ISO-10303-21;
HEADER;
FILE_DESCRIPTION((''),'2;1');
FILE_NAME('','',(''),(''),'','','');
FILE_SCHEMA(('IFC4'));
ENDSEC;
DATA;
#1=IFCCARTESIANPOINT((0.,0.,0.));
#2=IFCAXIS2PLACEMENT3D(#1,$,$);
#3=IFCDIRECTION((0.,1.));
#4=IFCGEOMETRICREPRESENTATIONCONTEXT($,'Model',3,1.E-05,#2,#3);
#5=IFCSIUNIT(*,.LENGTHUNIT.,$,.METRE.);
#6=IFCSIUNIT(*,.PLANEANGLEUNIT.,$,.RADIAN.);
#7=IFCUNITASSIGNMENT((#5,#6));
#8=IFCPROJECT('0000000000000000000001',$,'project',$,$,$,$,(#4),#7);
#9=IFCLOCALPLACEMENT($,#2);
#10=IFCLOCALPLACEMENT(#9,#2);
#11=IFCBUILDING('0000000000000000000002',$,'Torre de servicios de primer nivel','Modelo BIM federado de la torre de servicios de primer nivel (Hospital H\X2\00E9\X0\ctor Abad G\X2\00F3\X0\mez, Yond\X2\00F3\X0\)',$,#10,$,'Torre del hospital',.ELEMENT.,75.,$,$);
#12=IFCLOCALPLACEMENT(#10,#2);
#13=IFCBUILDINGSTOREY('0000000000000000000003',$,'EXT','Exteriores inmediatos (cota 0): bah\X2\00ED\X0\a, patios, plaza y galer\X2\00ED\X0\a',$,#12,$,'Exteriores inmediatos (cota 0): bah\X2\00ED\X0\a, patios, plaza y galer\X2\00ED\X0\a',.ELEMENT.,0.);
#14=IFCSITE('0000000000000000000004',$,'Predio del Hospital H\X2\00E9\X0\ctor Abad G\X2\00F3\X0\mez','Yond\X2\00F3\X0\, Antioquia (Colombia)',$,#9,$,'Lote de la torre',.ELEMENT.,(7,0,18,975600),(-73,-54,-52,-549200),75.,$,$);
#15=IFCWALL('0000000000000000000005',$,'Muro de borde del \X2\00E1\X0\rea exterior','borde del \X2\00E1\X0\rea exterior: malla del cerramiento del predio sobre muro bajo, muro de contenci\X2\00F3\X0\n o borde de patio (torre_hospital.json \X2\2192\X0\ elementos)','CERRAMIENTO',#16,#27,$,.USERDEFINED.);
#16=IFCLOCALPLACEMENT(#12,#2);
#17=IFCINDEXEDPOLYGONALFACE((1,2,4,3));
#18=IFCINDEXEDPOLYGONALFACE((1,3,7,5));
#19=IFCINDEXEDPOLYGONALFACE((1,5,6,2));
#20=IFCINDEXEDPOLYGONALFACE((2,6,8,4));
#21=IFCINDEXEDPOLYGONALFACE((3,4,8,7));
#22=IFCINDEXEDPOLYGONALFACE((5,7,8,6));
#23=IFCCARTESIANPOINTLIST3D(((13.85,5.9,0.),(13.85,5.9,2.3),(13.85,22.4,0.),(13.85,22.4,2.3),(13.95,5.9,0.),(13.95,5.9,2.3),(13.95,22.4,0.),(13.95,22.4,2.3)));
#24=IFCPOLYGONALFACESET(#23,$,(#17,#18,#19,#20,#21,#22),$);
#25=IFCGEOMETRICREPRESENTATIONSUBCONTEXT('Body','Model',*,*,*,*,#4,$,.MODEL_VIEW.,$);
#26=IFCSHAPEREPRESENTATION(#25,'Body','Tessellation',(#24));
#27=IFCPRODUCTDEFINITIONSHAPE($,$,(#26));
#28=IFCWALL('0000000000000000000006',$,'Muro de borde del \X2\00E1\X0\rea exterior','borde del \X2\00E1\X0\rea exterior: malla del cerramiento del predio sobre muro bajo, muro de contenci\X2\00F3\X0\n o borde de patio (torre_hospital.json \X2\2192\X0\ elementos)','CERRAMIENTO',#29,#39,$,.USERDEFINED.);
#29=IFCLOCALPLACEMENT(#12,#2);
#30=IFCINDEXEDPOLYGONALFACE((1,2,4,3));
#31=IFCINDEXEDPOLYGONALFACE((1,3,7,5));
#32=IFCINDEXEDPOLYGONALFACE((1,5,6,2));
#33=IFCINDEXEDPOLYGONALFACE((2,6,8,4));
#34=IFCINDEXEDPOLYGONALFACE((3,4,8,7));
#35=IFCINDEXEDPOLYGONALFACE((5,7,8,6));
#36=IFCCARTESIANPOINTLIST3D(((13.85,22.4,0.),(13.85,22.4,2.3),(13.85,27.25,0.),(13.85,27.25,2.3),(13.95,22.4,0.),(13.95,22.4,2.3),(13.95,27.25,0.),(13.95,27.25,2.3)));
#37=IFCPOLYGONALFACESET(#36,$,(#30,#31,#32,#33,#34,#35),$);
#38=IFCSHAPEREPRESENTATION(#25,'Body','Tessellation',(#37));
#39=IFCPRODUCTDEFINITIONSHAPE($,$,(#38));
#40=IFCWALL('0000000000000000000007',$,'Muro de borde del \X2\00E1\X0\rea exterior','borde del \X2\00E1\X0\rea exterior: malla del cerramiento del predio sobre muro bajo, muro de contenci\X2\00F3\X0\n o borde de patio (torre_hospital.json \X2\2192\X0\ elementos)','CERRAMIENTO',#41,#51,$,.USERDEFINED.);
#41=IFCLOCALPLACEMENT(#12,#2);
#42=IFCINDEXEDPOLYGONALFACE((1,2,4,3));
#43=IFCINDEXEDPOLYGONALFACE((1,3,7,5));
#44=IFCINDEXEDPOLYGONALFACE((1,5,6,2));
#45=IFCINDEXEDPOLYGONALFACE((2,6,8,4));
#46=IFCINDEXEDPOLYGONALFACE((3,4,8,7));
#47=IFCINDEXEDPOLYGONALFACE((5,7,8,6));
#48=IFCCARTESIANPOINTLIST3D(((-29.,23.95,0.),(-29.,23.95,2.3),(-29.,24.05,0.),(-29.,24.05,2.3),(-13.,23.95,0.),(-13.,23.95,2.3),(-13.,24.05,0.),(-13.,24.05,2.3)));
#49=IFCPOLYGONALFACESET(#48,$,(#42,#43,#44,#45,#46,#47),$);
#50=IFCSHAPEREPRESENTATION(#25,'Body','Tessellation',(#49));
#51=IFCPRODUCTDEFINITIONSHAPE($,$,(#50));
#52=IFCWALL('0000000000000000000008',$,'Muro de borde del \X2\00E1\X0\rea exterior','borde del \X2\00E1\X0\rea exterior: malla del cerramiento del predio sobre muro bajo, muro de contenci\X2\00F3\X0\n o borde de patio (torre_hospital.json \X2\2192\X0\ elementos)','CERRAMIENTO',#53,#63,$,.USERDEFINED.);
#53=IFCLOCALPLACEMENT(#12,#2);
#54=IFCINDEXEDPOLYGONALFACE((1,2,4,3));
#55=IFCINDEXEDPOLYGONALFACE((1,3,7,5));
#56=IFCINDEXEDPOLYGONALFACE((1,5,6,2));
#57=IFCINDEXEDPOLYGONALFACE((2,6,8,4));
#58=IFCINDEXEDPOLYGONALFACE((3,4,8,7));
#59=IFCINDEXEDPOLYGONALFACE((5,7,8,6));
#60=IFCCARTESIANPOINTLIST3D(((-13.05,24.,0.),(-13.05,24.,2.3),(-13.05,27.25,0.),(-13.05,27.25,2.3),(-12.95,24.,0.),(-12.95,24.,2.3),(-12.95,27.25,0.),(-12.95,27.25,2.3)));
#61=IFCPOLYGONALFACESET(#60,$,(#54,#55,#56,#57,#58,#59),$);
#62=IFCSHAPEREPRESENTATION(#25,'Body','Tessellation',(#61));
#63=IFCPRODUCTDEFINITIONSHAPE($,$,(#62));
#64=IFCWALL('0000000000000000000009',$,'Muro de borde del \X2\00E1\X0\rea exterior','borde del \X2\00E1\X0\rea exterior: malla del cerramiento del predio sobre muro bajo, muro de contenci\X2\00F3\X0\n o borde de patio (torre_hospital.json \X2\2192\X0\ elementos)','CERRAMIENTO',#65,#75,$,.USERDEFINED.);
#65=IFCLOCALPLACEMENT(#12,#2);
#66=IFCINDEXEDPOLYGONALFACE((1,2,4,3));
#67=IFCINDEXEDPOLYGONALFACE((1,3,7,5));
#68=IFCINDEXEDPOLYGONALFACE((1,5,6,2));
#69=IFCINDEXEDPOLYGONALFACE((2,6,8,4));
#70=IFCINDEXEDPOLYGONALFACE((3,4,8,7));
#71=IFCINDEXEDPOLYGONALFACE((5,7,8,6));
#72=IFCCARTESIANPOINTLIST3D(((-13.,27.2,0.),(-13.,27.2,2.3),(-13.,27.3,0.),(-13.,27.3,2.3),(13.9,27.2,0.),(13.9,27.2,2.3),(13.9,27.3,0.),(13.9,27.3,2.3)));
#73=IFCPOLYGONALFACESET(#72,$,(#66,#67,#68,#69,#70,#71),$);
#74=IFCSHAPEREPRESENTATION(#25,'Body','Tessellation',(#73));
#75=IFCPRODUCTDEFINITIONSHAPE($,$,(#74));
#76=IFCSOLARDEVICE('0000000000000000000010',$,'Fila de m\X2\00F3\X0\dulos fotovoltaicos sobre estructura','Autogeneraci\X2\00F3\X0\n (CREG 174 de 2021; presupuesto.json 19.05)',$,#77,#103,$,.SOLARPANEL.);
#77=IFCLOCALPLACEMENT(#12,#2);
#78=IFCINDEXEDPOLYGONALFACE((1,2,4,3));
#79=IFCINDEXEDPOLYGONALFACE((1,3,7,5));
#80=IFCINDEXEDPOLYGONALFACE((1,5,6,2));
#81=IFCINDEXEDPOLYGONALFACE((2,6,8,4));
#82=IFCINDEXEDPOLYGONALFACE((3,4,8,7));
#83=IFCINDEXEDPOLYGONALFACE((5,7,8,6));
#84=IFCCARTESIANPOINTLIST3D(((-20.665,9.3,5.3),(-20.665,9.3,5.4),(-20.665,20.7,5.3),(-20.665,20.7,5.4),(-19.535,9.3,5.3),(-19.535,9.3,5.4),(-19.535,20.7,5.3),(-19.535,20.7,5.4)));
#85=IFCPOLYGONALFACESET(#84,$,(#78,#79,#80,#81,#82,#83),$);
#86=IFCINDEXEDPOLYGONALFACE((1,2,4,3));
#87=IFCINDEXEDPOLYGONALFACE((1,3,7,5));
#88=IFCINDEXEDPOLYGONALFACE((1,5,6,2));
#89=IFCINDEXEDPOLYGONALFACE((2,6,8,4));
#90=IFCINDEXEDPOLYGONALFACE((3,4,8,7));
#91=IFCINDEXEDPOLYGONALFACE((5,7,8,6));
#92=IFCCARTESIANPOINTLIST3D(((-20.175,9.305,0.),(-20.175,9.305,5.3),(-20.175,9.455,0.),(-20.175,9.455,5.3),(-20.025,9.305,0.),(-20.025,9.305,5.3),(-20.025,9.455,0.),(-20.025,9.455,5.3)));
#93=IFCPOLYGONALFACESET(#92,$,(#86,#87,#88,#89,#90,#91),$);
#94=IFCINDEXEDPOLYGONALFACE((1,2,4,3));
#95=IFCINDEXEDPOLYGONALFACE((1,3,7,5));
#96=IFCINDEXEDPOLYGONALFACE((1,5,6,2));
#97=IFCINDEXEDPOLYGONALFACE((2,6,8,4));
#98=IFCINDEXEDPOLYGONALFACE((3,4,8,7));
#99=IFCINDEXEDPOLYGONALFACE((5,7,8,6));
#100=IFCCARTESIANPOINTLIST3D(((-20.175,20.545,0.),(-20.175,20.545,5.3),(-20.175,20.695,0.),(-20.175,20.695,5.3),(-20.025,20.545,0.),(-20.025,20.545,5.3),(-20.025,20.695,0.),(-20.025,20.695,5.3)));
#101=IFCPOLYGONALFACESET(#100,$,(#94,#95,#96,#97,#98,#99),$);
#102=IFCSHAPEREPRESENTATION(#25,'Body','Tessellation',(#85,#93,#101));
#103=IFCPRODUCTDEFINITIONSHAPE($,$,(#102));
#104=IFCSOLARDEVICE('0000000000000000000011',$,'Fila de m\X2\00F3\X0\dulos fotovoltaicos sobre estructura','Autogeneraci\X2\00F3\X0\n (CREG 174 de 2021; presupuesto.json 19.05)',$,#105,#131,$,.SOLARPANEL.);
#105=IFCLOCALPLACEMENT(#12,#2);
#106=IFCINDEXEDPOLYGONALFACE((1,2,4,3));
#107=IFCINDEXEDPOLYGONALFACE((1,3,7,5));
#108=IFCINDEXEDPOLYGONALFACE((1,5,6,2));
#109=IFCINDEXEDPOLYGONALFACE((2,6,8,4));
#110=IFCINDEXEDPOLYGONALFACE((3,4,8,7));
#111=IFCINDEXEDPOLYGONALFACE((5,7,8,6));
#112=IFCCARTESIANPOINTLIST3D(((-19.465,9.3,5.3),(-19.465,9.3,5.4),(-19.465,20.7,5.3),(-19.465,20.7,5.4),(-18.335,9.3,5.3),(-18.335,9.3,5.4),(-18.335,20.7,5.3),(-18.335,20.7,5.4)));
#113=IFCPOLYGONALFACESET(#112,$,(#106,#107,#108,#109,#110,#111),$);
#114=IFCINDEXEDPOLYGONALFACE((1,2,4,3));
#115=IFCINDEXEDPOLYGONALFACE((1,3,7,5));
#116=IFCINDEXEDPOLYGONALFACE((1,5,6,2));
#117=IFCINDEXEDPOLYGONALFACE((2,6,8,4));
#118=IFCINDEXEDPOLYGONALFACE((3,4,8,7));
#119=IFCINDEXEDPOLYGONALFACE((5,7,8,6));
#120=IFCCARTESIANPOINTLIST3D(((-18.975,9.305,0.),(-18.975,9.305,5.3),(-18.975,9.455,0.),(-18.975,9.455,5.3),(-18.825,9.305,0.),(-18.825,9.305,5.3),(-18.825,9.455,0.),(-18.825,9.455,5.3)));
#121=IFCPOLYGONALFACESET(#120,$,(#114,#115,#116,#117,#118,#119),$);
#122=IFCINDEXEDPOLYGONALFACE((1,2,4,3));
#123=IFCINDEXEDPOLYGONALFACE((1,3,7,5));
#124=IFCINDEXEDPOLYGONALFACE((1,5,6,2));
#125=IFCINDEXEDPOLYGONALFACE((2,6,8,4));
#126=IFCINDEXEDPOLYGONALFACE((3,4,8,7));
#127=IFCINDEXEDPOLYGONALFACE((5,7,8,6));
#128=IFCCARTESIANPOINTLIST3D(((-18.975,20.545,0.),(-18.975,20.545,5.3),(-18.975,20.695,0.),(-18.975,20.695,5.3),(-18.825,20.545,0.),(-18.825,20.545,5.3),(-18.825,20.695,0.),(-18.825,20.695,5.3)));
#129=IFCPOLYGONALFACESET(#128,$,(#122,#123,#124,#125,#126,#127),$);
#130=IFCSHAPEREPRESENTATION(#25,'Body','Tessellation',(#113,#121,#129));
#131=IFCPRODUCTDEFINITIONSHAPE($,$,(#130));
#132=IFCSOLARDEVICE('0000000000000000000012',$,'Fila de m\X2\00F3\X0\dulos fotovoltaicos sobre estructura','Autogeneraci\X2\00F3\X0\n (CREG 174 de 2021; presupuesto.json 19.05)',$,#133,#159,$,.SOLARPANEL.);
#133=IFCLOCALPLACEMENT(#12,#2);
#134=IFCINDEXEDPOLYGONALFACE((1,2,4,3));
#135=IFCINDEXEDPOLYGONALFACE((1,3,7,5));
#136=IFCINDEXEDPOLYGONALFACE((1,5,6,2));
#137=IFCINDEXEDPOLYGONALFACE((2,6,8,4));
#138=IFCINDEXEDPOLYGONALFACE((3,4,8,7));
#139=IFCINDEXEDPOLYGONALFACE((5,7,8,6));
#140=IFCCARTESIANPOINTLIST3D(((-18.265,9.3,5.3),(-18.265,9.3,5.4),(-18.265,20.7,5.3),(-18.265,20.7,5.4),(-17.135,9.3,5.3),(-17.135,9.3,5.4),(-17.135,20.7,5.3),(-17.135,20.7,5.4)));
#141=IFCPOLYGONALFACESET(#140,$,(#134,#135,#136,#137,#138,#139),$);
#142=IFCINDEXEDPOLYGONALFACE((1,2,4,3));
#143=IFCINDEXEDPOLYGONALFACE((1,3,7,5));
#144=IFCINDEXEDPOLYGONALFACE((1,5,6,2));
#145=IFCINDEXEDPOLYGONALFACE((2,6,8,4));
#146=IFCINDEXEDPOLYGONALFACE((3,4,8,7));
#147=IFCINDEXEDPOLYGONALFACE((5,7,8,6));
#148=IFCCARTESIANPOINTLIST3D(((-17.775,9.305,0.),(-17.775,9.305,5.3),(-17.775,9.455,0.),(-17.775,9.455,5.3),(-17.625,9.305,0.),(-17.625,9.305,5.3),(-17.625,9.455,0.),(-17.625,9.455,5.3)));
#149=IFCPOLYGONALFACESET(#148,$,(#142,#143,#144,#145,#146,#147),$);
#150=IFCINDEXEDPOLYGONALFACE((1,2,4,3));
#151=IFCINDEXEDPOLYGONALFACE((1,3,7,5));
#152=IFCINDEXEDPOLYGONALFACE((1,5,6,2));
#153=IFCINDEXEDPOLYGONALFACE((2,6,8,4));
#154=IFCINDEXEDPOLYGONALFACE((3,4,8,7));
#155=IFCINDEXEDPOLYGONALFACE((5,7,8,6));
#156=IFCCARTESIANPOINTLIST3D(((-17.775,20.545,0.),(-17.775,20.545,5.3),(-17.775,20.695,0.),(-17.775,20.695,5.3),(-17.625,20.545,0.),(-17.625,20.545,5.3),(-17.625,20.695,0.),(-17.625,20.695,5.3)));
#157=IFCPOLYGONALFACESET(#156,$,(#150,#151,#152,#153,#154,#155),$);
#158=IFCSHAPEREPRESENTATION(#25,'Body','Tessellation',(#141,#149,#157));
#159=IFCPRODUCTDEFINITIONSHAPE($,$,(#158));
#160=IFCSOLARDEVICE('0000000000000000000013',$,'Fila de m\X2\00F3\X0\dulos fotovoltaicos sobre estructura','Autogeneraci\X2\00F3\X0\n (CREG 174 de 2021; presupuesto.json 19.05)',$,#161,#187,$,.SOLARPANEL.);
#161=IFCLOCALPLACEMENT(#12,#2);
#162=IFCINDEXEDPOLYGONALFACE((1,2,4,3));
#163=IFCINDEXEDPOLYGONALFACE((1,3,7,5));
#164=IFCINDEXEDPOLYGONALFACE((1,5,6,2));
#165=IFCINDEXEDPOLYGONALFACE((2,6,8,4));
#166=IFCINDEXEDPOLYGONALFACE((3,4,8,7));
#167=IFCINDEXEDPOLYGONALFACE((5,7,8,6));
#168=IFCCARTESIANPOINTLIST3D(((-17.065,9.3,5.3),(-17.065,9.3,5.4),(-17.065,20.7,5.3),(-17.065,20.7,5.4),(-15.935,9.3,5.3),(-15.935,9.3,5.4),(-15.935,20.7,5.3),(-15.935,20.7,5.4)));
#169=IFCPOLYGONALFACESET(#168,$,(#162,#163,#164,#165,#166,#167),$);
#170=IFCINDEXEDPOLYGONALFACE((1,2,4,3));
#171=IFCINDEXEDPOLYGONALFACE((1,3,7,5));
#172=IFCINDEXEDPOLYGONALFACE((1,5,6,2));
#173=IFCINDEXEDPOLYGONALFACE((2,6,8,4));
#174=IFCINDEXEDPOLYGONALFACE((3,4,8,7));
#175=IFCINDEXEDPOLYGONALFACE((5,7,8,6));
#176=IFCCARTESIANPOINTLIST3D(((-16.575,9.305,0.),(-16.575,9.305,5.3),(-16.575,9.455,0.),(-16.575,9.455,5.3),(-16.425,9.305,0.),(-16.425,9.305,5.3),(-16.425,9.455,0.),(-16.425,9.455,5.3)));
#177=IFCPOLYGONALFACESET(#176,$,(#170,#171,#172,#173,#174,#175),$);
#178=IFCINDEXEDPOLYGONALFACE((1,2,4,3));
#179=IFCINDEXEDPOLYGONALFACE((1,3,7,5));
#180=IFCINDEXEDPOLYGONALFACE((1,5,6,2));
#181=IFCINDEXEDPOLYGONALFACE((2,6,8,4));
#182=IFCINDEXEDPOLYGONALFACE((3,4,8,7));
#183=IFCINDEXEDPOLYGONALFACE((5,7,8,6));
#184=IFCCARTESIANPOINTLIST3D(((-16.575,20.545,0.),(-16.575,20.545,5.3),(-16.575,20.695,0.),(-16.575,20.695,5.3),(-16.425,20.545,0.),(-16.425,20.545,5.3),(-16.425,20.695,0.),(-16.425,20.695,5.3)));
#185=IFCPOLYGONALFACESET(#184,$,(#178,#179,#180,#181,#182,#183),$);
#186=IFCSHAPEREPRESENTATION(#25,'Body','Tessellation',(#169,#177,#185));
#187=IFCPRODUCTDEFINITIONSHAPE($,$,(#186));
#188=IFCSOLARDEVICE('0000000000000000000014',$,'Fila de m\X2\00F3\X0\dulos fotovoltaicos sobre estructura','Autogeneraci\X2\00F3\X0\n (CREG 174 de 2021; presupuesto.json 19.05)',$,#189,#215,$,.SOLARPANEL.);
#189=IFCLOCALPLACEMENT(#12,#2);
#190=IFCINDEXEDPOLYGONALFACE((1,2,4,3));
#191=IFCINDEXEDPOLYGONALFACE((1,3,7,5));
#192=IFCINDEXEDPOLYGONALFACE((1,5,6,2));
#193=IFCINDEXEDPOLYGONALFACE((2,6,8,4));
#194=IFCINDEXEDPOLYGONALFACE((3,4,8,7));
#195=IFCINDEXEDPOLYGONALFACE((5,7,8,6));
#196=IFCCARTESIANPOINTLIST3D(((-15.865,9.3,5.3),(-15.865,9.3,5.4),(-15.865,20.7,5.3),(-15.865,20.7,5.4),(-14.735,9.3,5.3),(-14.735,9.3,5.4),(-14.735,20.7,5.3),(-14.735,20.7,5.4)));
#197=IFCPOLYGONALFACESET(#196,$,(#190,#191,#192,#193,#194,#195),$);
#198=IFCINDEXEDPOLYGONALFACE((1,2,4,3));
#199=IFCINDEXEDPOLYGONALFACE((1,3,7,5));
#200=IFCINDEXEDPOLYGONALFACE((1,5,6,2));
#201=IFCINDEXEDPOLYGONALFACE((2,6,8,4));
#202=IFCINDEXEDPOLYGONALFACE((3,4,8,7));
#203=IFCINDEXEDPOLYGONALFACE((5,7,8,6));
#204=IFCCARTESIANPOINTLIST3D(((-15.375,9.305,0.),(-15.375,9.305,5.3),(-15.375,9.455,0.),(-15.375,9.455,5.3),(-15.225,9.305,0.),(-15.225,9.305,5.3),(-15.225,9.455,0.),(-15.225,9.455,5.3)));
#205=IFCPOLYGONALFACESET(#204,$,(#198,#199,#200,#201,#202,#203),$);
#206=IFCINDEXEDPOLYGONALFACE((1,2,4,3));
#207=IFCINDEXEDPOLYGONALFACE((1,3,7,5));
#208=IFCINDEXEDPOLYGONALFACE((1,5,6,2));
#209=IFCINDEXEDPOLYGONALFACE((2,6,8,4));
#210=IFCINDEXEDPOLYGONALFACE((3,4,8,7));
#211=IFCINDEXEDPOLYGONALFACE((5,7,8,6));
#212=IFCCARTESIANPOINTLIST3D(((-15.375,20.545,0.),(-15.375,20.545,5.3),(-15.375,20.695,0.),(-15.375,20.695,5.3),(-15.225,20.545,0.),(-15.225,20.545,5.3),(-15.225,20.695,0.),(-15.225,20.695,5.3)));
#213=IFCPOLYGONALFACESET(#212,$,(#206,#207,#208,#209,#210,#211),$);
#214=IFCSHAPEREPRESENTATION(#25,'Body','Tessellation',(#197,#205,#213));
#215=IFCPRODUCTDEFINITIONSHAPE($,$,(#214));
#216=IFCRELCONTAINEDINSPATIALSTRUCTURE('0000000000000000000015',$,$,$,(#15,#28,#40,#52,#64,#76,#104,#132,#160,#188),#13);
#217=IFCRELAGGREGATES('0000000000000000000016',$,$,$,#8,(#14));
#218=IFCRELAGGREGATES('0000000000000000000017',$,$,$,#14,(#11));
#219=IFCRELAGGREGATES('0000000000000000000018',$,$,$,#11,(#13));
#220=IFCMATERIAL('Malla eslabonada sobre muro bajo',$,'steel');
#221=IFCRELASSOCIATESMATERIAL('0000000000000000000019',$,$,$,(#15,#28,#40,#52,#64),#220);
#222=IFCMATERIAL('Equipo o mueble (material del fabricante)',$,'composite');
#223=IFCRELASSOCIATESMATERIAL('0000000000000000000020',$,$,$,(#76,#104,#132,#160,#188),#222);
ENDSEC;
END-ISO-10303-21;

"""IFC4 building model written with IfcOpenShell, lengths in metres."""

from ifc_helpers import new_model, si_unit, direction, frame, origin, place, context, subcontext, project, spatial, rectangle, extrude, material, element, save


model = new_model("IFC4")

# Units and contexts
model_context = context("Model", 3, precision=1e-05, world=origin(), true_north=direction((0.0, 1.0)))
body_context = subcontext(model_context, "Body", "Model", "MODEL_VIEW")
ifc_project = project(units=[si_unit("LENGTHUNIT", "METRE"), si_unit("PLANEANGLEUNIT", "RADIAN")], contexts=[model_context])

# Site, building, storey
site_placement = place(None, origin())
site = spatial("IfcSite", under=ifc_project, at=site_placement, Name="Predio del Hospital Héctor Abad Gómez", Description="Yondó, Antioquia (Colombia)", LongName="Lote de la torre", CompositionType="ELEMENT", RefLatitude=(7, 0, 18, 975600), RefLongitude=(-73, -54, -52, -549200), RefElevation=75.0)
building_placement = place(site_placement, origin())
building = spatial("IfcBuilding", under=site, at=building_placement, Name="Torre de servicios de primer nivel", Description="Modelo BIM federado de la torre de servicios de primer nivel (Hospital Héctor Abad Gómez, Yondó)", LongName="Torre del hospital", CompositionType="ELEMENT", ElevationOfRefHeight=75.0)
placement = place(building_placement, origin())
storey = spatial("IfcBuildingStorey", under=building, at=placement, Name="EXT", Description="Exteriores inmediatos (cota 0): bahía, patios, plaza y galería", LongName="Exteriores inmediatos (cota 0): bahía, patios, plaza y galería", CompositionType="ELEMENT", Elevation=0.0)

# Shared definitions
ifc_material_1 = material(Name="Malla eslabonada sobre muro bajo", Category="steel")

# Walls
element("IfcWall", 1, at=placement, inside=storey, material=ifc_material_1, Name="Muro de borde del área exterior", Description="borde del área exterior: malla del cerramiento del predio sobre muro bajo, muro de contención o borde de patio (torre_hospital.json → elementos)", ObjectType="CERRAMIENTO", PredefinedType="USERDEFINED", context=body_context, shape_type="SweptSolid", body=[
    extrude(rectangle(XDim=0.1, YDim=16.5), frame((13.9, 14.15, 0.0)), (0.0, 0.0, 1.0), 2.3),
])
element("IfcWall", 2, at=placement, inside=storey, material=ifc_material_1, Name="Muro de borde del área exterior", Description="borde del área exterior: malla del cerramiento del predio sobre muro bajo, muro de contención o borde de patio (torre_hospital.json → elementos)", ObjectType="CERRAMIENTO", PredefinedType="USERDEFINED", context=body_context, shape_type="SweptSolid", body=[
    extrude(rectangle(XDim=0.1, YDim=4.85), frame((13.9, 24.825, 0.0)), (0.0, 0.0, 1.0), 2.3),
])
element("IfcWall", 3, at=placement, inside=storey, material=ifc_material_1, Name="Muro de borde del área exterior", Description="borde del área exterior: malla del cerramiento del predio sobre muro bajo, muro de contención o borde de patio (torre_hospital.json → elementos)", ObjectType="CERRAMIENTO", PredefinedType="USERDEFINED", context=body_context, shape_type="SweptSolid", body=[
    extrude(rectangle(XDim=16.0, YDim=0.1), frame((-21.0, 24.0, 0.0)), (0.0, 0.0, 1.0), 2.3),
])
element("IfcWall", 4, at=placement, inside=storey, material=ifc_material_1, Name="Muro de borde del área exterior", Description="borde del área exterior: malla del cerramiento del predio sobre muro bajo, muro de contención o borde de patio (torre_hospital.json → elementos)", ObjectType="CERRAMIENTO", PredefinedType="USERDEFINED", context=body_context, shape_type="SweptSolid", body=[
    extrude(rectangle(XDim=0.1, YDim=3.25), frame((-13.0, 25.625, 0.0)), (0.0, 0.0, 1.0), 2.3),
])
element("IfcWall", 5, at=placement, inside=storey, material=ifc_material_1, Name="Muro de borde del área exterior", Description="borde del área exterior: malla del cerramiento del predio sobre muro bajo, muro de contención o borde de patio (torre_hospital.json → elementos)", ObjectType="CERRAMIENTO", PredefinedType="USERDEFINED", context=body_context, shape_type="SweptSolid", body=[
    extrude(rectangle(XDim=26.9, YDim=0.1), frame((0.45, 27.25, 0.0)), (0.0, 0.0, 1.0), 2.3),
])

# Solar devices
ifc_material_2 = material(Name="Equipo o mueble (material del fabricante)", Category="composite")
element("IfcSolarDevice", 6, at=placement, inside=storey, material=ifc_material_2, Name="Fila de módulos fotovoltaicos sobre estructura", Description="Autogeneración (CREG 174 de 2021; presupuesto.json 19.05)", PredefinedType="SOLARPANEL", context=body_context, shape_type="SweptSolid", body=[
    extrude(rectangle(XDim=11.4, YDim=1.13), frame((-20.1, 15.0, 5.3), z_axis=(0.0, 0.0, 1.0), x_axis=(0.0, 1.0, 0.0)), (0.0, 0.0, 1.0), 0.1),
    extrude(rectangle(XDim=0.15, YDim=0.15), frame((-20.1, 9.38, 0.0), z_axis=(0.0, 0.0, 1.0), x_axis=(0.0, 1.0, 0.0)), (0.0, 0.0, 1.0), 5.3),
    extrude(rectangle(XDim=0.15, YDim=0.15), frame((-20.1, 20.62, 0.0), z_axis=(0.0, 0.0, 1.0), x_axis=(0.0, 1.0, 0.0)), (0.0, 0.0, 1.0), 5.3),
])
element("IfcSolarDevice", 7, at=placement, inside=storey, material=ifc_material_2, Name="Fila de módulos fotovoltaicos sobre estructura", Description="Autogeneración (CREG 174 de 2021; presupuesto.json 19.05)", PredefinedType="SOLARPANEL", context=body_context, shape_type="SweptSolid", body=[
    extrude(rectangle(XDim=11.4, YDim=1.13), frame((-18.9, 15.0, 5.3), z_axis=(0.0, 0.0, 1.0), x_axis=(0.0, 1.0, 0.0)), (0.0, 0.0, 1.0), 0.1),
    extrude(rectangle(XDim=0.15, YDim=0.15), frame((-18.9, 9.38, 0.0), z_axis=(0.0, 0.0, 1.0), x_axis=(0.0, 1.0, 0.0)), (0.0, 0.0, 1.0), 5.3),
    extrude(rectangle(XDim=0.15, YDim=0.15), frame((-18.9, 20.62, 0.0), z_axis=(0.0, 0.0, 1.0), x_axis=(0.0, 1.0, 0.0)), (0.0, 0.0, 1.0), 5.3),
])
element("IfcSolarDevice", 8, at=placement, inside=storey, material=ifc_material_2, Name="Fila de módulos fotovoltaicos sobre estructura", Description="Autogeneración (CREG 174 de 2021; presupuesto.json 19.05)", PredefinedType="SOLARPANEL", context=body_context, shape_type="SweptSolid", body=[
    extrude(rectangle(XDim=11.4, YDim=1.13), frame((-17.7, 15.0, 5.3), z_axis=(0.0, 0.0, 1.0), x_axis=(0.0, 1.0, 0.0)), (0.0, 0.0, 1.0), 0.1),
    extrude(rectangle(XDim=0.15, YDim=0.15), frame((-17.7, 9.38, 0.0), z_axis=(0.0, 0.0, 1.0), x_axis=(0.0, 1.0, 0.0)), (0.0, 0.0, 1.0), 5.3),
    extrude(rectangle(XDim=0.15, YDim=0.15), frame((-17.7, 20.62, 0.0), z_axis=(0.0, 0.0, 1.0), x_axis=(0.0, 1.0, 0.0)), (0.0, 0.0, 1.0), 5.3),
])
element("IfcSolarDevice", 9, at=placement, inside=storey, material=ifc_material_2, Name="Fila de módulos fotovoltaicos sobre estructura", Description="Autogeneración (CREG 174 de 2021; presupuesto.json 19.05)", PredefinedType="SOLARPANEL", context=body_context, shape_type="SweptSolid", body=[
    extrude(rectangle(XDim=11.4, YDim=1.13), frame((-16.5, 15.0, 5.3), z_axis=(0.0, 0.0, 1.0), x_axis=(0.0, 1.0, 0.0)), (0.0, 0.0, 1.0), 0.1),
    extrude(rectangle(XDim=0.15, YDim=0.15), frame((-16.5, 9.38, 0.0), z_axis=(0.0, 0.0, 1.0), x_axis=(0.0, 1.0, 0.0)), (0.0, 0.0, 1.0), 5.3),
    extrude(rectangle(XDim=0.15, YDim=0.15), frame((-16.5, 20.62, 0.0), z_axis=(0.0, 0.0, 1.0), x_axis=(0.0, 1.0, 0.0)), (0.0, 0.0, 1.0), 5.3),
])
element("IfcSolarDevice", 10, at=placement, inside=storey, material=ifc_material_2, Name="Fila de módulos fotovoltaicos sobre estructura", Description="Autogeneración (CREG 174 de 2021; presupuesto.json 19.05)", PredefinedType="SOLARPANEL", context=body_context, shape_type="SweptSolid", body=[
    extrude(rectangle(XDim=11.4, YDim=1.13), frame((-15.3, 15.0, 5.3), z_axis=(0.0, 0.0, 1.0), x_axis=(0.0, 1.0, 0.0)), (0.0, 0.0, 1.0), 0.1),
    extrude(rectangle(XDim=0.15, YDim=0.15), frame((-15.3, 9.38, 0.0), z_axis=(0.0, 0.0, 1.0), x_axis=(0.0, 1.0, 0.0)), (0.0, 0.0, 1.0), 5.3),
    extrude(rectangle(XDim=0.15, YDim=0.15), frame((-15.3, 20.62, 0.0), z_axis=(0.0, 0.0, 1.0), x_axis=(0.0, 1.0, 0.0)), (0.0, 0.0, 1.0), 5.3),
])

save(model, "model.ifc")
